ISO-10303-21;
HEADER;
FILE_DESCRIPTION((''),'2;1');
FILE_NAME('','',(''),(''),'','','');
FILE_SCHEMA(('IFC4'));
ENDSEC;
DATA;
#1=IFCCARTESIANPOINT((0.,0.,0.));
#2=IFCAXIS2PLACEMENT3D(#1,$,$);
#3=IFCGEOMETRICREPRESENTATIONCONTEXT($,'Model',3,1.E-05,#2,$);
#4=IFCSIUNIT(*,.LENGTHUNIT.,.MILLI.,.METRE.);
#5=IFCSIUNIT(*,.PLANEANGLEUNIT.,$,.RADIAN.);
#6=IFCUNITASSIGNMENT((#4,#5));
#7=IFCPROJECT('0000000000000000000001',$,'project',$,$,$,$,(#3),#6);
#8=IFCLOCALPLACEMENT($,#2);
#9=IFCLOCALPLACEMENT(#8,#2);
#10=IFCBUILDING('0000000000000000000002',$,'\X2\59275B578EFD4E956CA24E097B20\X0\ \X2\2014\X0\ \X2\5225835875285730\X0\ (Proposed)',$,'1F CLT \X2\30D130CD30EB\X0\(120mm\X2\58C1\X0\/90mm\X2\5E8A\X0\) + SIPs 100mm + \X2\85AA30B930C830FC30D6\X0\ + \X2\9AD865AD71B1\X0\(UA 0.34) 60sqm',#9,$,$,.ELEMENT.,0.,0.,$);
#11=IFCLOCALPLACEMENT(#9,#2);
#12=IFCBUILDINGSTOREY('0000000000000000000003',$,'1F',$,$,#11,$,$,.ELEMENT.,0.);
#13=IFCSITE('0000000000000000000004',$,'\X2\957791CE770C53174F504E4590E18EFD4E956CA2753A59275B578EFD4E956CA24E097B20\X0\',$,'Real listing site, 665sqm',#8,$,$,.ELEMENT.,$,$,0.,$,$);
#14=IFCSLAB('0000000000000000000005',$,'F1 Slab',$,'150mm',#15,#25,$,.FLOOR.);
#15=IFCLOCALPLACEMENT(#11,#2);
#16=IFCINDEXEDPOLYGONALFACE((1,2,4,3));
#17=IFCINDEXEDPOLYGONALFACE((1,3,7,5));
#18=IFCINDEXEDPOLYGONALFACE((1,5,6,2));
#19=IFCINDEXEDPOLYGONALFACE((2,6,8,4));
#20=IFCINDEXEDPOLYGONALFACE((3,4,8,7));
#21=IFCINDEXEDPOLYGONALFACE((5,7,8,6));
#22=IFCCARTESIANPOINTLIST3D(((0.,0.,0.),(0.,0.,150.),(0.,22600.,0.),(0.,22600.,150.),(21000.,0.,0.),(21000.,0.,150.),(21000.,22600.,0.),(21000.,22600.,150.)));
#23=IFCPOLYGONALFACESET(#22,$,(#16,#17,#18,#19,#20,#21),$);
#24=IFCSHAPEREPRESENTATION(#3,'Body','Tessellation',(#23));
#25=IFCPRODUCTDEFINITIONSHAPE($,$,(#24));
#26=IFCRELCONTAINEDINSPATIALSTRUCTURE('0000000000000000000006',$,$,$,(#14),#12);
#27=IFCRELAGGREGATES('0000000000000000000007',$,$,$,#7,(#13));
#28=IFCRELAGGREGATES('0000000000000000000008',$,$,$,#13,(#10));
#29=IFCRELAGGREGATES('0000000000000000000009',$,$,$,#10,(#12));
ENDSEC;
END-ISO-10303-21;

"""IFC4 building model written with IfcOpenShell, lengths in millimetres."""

from ifc_helpers import new_model, si_unit, frame_2d, origin, place, context, project, spatial, rectangle, extrude, element, save


model = new_model("IFC4")

# Units and contexts
model_context = context("Model", 3, precision=1e-05, world=origin())
ifc_project = project(units=[si_unit("LENGTHUNIT", "METRE", prefix="MILLI"), si_unit("PLANEANGLEUNIT", "RADIAN")], contexts=[model_context])

# Site, building, storey
site_placement = place(None, origin())
site = spatial("IfcSite", under=ifc_project, at=site_placement, Name="長野県北佐久郡軽井沢町大字軽井沢三笠", ObjectType="Real listing site, 665sqm", CompositionType="ELEMENT", RefElevation=0.0)
building_placement = place(site_placement, origin())
building = spatial("IfcBuilding", under=site, at=building_placement, Name="大字軽井沢三笠 — 別荘用地 (Proposed)", ObjectType="1F CLT パネル(120mm壁/90mm床) + SIPs 100mm + 薪ストーブ + 高断熱(UA 0.34) 60sqm", CompositionType="ELEMENT", ElevationOfRefHeight=0.0, ElevationOfTerrain=0.0)
storey_placement = place(building_placement, origin())
storey = spatial("IfcBuildingStorey", under=building, at=storey_placement, Name="1F", CompositionType="ELEMENT", Elevation=0.0)

# Slab
slab_placement = place(storey_placement, origin())
element("IfcSlab", 1, at=slab_placement, inside=storey, Name="F1 Slab", ObjectType="150mm", PredefinedType="FLOOR", context=model_context, shape_type="SweptSolid", body=[
    extrude(rectangle(XDim=21000.0, YDim=22600.0, at=frame_2d((10500.0, 11300.0))), origin(), (0.0, 0.0, 1.0), 150.0),
])

save(model, "model.ifc")
